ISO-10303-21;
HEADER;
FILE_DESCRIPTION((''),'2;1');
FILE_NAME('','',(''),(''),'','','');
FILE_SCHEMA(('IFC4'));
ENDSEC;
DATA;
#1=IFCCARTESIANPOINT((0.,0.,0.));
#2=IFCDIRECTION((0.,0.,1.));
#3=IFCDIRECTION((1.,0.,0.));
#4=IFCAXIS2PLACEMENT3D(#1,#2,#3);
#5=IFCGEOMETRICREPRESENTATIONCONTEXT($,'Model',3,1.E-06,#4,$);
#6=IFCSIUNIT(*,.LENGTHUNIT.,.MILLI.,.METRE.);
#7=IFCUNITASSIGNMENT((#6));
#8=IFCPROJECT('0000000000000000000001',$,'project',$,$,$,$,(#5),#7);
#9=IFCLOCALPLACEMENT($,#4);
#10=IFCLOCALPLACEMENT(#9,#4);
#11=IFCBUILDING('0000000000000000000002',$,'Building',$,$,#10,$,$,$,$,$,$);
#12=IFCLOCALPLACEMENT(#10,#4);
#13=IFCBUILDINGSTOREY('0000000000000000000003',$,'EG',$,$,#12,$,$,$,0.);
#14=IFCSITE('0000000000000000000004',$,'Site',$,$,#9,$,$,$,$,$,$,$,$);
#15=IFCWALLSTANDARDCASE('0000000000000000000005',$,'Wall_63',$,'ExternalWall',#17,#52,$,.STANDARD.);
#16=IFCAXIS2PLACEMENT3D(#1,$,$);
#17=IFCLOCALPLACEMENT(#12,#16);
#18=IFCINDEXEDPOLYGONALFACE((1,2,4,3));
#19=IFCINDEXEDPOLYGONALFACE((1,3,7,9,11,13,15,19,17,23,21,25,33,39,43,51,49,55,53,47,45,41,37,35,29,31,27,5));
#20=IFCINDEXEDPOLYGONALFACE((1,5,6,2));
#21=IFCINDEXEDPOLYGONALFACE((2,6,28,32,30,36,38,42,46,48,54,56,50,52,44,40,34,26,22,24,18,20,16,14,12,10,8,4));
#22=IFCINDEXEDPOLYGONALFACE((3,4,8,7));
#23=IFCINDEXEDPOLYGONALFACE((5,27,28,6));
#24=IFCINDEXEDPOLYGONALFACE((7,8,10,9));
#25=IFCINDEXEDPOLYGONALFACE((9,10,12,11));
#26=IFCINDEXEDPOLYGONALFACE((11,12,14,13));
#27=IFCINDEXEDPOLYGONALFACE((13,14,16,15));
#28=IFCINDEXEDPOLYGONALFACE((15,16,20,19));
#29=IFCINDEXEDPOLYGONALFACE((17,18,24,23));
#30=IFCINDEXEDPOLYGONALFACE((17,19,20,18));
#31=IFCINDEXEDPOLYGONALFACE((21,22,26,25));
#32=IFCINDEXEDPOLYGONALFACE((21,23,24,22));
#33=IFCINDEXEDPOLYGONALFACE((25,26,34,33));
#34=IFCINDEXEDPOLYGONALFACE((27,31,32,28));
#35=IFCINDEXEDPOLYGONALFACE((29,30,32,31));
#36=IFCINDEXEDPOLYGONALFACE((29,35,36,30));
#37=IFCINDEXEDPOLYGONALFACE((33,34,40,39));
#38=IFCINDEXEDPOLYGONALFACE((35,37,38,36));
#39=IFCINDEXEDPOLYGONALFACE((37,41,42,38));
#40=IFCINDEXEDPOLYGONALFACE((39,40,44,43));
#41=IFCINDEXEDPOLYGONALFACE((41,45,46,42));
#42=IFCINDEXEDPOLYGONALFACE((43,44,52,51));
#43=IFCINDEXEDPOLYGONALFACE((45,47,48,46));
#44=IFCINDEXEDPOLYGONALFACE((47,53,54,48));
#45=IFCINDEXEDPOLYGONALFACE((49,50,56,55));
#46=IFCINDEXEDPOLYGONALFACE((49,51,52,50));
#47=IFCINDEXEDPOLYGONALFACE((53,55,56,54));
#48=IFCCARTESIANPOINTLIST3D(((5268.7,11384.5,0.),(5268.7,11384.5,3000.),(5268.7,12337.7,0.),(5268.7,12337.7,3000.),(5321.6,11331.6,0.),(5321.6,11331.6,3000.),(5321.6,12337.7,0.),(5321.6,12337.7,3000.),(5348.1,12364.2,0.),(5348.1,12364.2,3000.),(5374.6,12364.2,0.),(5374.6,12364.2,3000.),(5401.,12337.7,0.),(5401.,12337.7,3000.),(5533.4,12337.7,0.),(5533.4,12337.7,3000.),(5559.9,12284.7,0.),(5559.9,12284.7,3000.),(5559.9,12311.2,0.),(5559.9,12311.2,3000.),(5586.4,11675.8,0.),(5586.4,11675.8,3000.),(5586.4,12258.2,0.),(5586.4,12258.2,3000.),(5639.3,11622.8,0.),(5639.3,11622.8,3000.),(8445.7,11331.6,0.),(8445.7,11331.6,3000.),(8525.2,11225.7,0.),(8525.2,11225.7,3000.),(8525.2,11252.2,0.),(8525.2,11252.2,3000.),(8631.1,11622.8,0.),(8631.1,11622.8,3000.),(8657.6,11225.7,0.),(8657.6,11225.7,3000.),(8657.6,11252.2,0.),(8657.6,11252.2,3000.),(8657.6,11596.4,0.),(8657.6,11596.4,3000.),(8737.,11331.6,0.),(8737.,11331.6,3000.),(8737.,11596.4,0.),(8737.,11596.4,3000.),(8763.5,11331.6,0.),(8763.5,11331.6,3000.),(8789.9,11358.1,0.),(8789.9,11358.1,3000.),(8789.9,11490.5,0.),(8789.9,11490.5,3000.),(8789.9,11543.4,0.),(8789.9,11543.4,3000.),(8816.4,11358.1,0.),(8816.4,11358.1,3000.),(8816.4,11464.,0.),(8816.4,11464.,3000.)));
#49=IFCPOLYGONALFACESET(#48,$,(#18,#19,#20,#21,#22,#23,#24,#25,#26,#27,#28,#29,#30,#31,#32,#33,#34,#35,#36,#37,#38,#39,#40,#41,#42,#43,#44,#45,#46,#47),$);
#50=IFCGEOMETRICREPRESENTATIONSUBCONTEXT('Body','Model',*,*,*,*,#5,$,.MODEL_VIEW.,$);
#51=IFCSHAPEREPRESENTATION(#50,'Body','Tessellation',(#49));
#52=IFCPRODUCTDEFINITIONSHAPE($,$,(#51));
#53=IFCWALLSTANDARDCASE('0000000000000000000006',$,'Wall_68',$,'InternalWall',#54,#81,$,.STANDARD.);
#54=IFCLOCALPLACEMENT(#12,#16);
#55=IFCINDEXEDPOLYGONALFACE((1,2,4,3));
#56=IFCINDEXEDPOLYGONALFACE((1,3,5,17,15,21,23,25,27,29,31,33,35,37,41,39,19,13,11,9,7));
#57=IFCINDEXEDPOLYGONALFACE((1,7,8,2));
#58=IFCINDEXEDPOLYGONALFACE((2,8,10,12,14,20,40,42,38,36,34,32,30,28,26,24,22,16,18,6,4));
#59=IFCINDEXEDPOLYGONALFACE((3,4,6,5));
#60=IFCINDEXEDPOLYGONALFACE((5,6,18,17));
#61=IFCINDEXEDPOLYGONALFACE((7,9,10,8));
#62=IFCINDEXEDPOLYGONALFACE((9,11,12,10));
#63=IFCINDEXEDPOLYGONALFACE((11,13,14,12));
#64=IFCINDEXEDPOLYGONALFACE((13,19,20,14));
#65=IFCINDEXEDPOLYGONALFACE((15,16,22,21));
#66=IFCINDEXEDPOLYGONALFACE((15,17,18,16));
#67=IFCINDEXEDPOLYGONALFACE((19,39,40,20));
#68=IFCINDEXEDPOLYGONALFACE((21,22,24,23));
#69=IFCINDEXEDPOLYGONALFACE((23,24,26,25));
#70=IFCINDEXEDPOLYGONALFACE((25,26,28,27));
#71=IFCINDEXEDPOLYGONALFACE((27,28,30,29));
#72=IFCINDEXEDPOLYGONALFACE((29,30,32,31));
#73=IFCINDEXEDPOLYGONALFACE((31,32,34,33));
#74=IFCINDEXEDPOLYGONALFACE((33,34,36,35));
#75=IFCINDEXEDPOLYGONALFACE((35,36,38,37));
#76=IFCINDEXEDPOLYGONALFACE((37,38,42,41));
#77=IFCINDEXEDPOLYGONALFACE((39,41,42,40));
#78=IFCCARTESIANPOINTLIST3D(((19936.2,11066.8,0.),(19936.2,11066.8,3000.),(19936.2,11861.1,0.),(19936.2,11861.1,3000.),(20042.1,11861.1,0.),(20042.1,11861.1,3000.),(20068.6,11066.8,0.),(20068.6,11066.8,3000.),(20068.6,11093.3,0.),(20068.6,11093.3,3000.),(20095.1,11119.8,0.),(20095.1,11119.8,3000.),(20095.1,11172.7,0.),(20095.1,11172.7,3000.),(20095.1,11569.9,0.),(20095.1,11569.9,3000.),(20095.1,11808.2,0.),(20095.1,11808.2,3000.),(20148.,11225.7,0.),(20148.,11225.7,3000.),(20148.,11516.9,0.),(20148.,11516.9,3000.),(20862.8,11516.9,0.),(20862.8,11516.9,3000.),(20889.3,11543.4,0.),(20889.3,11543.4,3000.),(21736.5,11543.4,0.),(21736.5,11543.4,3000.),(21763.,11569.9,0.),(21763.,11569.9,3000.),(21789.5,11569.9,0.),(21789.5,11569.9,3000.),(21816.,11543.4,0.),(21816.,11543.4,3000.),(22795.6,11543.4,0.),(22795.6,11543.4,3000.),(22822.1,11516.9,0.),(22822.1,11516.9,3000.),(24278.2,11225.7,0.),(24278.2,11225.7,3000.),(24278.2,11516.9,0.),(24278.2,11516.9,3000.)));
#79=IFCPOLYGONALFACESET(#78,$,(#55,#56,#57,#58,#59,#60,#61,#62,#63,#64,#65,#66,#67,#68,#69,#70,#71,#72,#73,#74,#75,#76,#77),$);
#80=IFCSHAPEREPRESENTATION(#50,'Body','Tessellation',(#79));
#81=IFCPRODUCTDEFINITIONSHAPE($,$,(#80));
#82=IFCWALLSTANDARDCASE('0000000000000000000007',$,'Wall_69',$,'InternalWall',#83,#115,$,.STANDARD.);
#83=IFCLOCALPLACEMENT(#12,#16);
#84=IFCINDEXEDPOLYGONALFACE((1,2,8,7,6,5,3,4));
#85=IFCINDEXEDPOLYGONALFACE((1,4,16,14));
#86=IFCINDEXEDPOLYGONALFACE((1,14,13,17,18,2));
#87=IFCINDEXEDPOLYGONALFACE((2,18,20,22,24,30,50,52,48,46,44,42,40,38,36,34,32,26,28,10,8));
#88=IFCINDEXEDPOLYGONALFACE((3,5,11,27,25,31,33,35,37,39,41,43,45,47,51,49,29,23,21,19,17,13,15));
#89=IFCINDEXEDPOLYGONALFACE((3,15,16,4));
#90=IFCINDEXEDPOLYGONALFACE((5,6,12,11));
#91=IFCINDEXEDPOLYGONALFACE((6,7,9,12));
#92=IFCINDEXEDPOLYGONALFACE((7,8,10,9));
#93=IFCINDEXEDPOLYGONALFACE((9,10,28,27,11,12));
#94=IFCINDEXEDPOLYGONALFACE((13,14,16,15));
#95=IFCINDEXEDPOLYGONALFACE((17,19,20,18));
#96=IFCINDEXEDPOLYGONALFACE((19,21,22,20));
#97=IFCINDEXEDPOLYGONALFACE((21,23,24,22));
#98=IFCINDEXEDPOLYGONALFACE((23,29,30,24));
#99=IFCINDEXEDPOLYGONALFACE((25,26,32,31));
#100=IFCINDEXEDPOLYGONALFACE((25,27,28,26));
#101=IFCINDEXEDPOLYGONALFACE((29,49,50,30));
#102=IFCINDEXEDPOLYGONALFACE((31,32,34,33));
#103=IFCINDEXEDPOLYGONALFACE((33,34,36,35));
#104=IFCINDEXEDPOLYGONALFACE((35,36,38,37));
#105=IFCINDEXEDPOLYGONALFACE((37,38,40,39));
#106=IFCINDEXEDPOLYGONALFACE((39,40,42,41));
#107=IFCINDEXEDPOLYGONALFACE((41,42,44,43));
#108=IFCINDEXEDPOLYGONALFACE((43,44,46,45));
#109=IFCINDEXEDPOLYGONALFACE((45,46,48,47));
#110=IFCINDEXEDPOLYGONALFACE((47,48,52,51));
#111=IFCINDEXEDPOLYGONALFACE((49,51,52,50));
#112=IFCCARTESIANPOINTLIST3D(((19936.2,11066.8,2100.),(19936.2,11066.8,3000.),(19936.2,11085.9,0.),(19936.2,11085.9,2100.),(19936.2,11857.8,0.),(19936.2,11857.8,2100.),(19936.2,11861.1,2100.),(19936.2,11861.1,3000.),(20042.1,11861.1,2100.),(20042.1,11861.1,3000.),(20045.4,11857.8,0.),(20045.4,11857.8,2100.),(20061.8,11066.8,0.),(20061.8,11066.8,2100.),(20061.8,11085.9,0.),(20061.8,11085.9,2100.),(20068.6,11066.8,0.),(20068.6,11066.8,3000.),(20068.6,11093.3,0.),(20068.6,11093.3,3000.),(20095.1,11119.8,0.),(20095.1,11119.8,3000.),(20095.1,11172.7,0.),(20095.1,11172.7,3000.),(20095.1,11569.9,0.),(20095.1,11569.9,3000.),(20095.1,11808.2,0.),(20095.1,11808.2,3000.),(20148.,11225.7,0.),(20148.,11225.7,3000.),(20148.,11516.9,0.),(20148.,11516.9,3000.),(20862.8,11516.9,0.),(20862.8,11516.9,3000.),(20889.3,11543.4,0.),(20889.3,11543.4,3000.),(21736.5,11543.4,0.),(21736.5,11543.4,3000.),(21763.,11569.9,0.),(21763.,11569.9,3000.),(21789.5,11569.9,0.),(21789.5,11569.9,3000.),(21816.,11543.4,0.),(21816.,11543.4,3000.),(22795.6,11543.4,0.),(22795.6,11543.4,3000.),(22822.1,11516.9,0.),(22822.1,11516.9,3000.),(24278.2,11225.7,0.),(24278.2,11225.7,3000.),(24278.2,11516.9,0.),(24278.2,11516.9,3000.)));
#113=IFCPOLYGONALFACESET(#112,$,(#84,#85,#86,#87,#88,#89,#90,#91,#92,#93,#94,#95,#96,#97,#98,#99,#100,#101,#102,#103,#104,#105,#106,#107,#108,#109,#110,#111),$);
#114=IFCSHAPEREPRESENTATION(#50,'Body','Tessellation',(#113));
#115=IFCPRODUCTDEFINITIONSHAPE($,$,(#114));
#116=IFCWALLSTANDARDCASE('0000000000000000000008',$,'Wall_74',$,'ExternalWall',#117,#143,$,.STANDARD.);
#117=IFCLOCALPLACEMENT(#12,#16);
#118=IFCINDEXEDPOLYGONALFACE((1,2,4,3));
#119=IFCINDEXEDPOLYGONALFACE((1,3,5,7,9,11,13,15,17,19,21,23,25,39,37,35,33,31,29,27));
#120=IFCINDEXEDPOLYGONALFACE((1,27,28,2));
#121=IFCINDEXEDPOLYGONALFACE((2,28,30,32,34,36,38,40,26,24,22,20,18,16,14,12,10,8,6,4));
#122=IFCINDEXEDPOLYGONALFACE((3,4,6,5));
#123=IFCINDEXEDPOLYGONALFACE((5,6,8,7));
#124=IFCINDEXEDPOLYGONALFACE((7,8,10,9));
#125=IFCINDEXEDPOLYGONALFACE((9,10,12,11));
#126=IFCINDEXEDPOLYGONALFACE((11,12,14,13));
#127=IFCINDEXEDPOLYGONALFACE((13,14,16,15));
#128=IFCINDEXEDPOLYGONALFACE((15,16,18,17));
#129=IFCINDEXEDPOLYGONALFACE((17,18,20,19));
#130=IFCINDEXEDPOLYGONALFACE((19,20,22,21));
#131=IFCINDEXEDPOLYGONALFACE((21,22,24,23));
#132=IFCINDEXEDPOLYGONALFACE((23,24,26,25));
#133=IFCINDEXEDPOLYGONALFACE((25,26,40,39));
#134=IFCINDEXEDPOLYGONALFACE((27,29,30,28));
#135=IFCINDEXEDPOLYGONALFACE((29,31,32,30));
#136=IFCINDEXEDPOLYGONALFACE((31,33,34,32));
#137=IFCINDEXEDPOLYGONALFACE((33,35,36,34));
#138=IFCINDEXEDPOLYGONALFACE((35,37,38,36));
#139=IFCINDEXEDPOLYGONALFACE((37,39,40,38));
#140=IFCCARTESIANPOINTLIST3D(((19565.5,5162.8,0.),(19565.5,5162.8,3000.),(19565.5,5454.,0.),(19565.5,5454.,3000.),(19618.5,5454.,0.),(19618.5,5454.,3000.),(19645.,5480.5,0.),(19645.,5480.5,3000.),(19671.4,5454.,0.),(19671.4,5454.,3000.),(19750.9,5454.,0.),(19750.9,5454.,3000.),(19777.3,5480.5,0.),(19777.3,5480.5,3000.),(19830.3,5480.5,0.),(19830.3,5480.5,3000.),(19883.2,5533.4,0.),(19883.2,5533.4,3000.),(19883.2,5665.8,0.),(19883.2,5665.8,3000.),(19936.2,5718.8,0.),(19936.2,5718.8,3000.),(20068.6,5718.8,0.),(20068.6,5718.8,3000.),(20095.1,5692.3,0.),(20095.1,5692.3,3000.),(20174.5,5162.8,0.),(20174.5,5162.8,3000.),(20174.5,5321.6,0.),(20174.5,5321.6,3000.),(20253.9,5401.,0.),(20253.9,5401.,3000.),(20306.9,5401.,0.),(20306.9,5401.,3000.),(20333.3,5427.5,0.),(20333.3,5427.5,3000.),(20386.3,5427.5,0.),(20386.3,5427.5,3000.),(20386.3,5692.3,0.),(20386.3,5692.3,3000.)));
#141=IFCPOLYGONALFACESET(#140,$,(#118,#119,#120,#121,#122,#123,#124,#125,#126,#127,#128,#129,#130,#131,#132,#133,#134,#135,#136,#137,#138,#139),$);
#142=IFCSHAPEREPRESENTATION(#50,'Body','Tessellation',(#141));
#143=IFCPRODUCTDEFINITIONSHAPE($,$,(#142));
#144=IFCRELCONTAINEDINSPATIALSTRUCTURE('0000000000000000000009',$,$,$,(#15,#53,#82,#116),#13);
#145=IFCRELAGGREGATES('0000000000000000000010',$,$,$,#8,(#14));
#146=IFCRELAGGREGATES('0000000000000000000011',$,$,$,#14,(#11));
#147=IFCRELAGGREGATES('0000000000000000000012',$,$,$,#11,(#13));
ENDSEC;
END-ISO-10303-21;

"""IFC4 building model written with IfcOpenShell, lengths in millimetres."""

from ifc_helpers import new_model, si_unit, frame, origin_with_axes, place, context, subcontext, project, spatial, polyline, rectangle, outline, extrude, element, save


model = new_model("IFC4")

# Units and contexts
model_context = context("Model", 3, precision=1e-06, world=origin_with_axes())
body_context = subcontext(model_context, "Body", "Model", "MODEL_VIEW")
ifc_project = project(units=[si_unit("LENGTHUNIT", "METRE", prefix="MILLI")], contexts=[model_context])

# Site, building, storey
site_placement = place(None, origin_with_axes())
site = spatial("IfcSite", under=ifc_project, at=site_placement, Name="Site")
building_placement = place(site_placement, origin_with_axes())
building = spatial("IfcBuilding", under=site, at=building_placement, Name="Building")
storey_placement = place(building_placement, origin_with_axes())
storey = spatial("IfcBuildingStorey", under=building, at=storey_placement, Name="EG", Elevation=0.0)

# Wall
wall_1_placement = place(storey_placement, origin_with_axes())
element("IfcWallStandardCase", 1, at=wall_1_placement, inside=storey, Name="Wall_63", ObjectType="ExternalWall", PredefinedType="STANDARD", context=body_context, shape_type="SweptSolid", body=[
    extrude(outline(polyline([(8525.2, 11225.7, 0.0), (8525.2, 11252.2, 0.0), (8445.7, 11331.6, 0.0), (5321.6, 11331.6, 0.0), (5268.7, 11384.5, 0.0), (5268.7, 12337.7, 0.0), (5321.6, 12337.7, 0.0), (5348.1, 12364.2, 0.0), (5374.6, 12364.2, 0.0), (5401.0, 12337.7, 0.0), (5533.4, 12337.7, 0.0), (5559.9, 12311.2, 0.0), (5559.9, 12284.7, 0.0), (5586.4, 12258.2, 0.0), (5586.4, 11675.8, 0.0), (5639.3, 11622.8, 0.0), (8631.1, 11622.8, 0.0), (8657.6, 11596.4, 0.0), (8737.0, 11596.4, 0.0), (8789.9, 11543.4, 0.0), (8789.9, 11490.5, 0.0), (8816.4, 11464.0, 0.0), (8816.4, 11358.1, 0.0), (8789.9, 11358.1, 0.0), (8763.5, 11331.6, 0.0), (8737.0, 11331.6, 0.0), (8657.6, 11252.2, 0.0), (8657.6, 11225.7, 0.0), (8525.2, 11225.7, 0.0)])), origin_with_axes(), (0.0, 0.0, 1.0), 3000.0),
])

# Wall
wall_2_placement = place(storey_placement, origin_with_axes())
element("IfcWallStandardCase", 2, at=wall_2_placement, inside=storey, Name="Wall_68", ObjectType="InternalWall", PredefinedType="STANDARD", context=body_context, shape_type="SweptSolid", body=[
    extrude(outline(polyline([(19936.2, 11066.8, 0.0), (19936.2, 11861.1, 0.0), (20042.1, 11861.1, 0.0), (20095.1, 11808.2, 0.0), (20095.1, 11569.9, 0.0), (20148.0, 11516.9, 0.0), (20862.8, 11516.9, 0.0), (20889.3, 11543.4, 0.0), (21736.5, 11543.4, 0.0), (21763.0, 11569.9, 0.0), (21789.5, 11569.9, 0.0), (21816.0, 11543.4, 0.0), (22795.6, 11543.4, 0.0), (22822.1, 11516.9, 0.0), (24278.2, 11516.9, 0.0), (24278.2, 11225.7, 0.0), (20148.0, 11225.7, 0.0), (20095.1, 11172.7, 0.0), (20095.1, 11119.8, 0.0), (20068.6, 11093.3, 0.0), (20068.6, 11066.8, 0.0), (19936.2, 11066.8, 0.0)])), origin_with_axes(), (0.0, 0.0, 1.0), 3000.0),
])

# Wall, openings
wall_3_placement = place(storey_placement, origin_with_axes())
wall_3 = element("IfcWallStandardCase", 3, at=wall_3_placement, inside=storey, Name="Wall_69", ObjectType="InternalWall", PredefinedType="STANDARD", context=body_context, shape_type="SweptSolid", body=[
    extrude(outline(polyline([(19936.2, 11066.8, 0.0), (19936.2, 11861.1, 0.0), (20042.1, 11861.1, 0.0), (20095.1, 11808.2, 0.0), (20095.1, 11569.9, 0.0), (20148.0, 11516.9, 0.0), (20862.8, 11516.9, 0.0), (20889.3, 11543.4, 0.0), (21736.5, 11543.4, 0.0), (21763.0, 11569.9, 0.0), (21789.5, 11569.9, 0.0), (21816.0, 11543.4, 0.0), (22795.6, 11543.4, 0.0), (22822.1, 11516.9, 0.0), (24278.2, 11516.9, 0.0), (24278.2, 11225.7, 0.0), (20148.0, 11225.7, 0.0), (20095.1, 11172.7, 0.0), (20095.1, 11119.8, 0.0), (20068.6, 11093.3, 0.0), (20068.6, 11066.8, 0.0), (19936.2, 11066.8, 0.0)])), origin_with_axes(), (0.0, 0.0, 1.0), 3000.0),
])
opening_1_placement = place(wall_3_placement, origin_with_axes())
element("IfcOpeningElement", 4, at=opening_1_placement, inside=storey, cuts=wall_3, context=body_context, shape_type="SweptSolid", body=[
    extrude(rectangle(XDim=1059.0, YDim=240.0), frame((19941.8, 10556.3, 0.0), z_axis=(0.0, 0.0, 1.0), x_axis=(0.0, 1.0, 0.0)), (0.0, 0.0, 1.0), 2100.0),
])
opening_2_placement = place(wall_3_placement, origin_with_axes())
element("IfcOpeningElement", 5, at=opening_2_placement, inside=storey, cuts=wall_3, context=body_context, shape_type="SweptSolid", body=[
    extrude(rectangle(XDim=847.2, YDim=240.0), frame((19941.8, 12281.5, 0.0), z_axis=(0.0, 0.0, 1.0), x_axis=(0.0, 1.0, 0.0)), (0.0, 0.0, 1.0), 2100.0),
])

# Wall, opening
wall_4_placement = place(storey_placement, origin_with_axes())
wall_4 = element("IfcWallStandardCase", 6, at=wall_4_placement, inside=storey, Name="Wall_74", ObjectType="ExternalWall", PredefinedType="STANDARD", context=body_context, shape_type="SweptSolid", body=[
    extrude(outline(polyline([(19565.5, 5162.8, 0.0), (19565.5, 5454.0, 0.0), (19618.5, 5454.0, 0.0), (19645.0, 5480.5, 0.0), (19671.4, 5454.0, 0.0), (19750.9, 5454.0, 0.0), (19777.3, 5480.5, 0.0), (19830.3, 5480.5, 0.0), (19883.2, 5533.4, 0.0), (19883.2, 5665.8, 0.0), (19936.2, 5718.8, 0.0), (20068.6, 5718.8, 0.0), (20095.1, 5692.3, 0.0), (20386.3, 5692.3, 0.0), (20386.3, 5427.5, 0.0), (20333.3, 5427.5, 0.0), (20306.9, 5401.0, 0.0), (20253.9, 5401.0, 0.0), (20174.5, 5321.6, 0.0), (20174.5, 5162.8, 0.0), (19565.5, 5162.8, 0.0)])), origin_with_axes(), (0.0, 0.0, 1.0), 3000.0),
])
opening_3_placement = place(wall_4_placement, origin_with_axes())
element("IfcOpeningElement", 7, at=opening_3_placement, inside=storey, cuts=wall_4, context=body_context, shape_type="SweptSolid", body=[
    extrude(rectangle(XDim=3600.7, YDim=185.3), frame((22196.6, 5696.1, 1000.0), z_axis=(0.0, 0.0, 1.0), x_axis=(1.0, 0.0, 0.0)), (0.0, 0.0, 1.0), 1000.0),
])

save(model, "model.ifc")
